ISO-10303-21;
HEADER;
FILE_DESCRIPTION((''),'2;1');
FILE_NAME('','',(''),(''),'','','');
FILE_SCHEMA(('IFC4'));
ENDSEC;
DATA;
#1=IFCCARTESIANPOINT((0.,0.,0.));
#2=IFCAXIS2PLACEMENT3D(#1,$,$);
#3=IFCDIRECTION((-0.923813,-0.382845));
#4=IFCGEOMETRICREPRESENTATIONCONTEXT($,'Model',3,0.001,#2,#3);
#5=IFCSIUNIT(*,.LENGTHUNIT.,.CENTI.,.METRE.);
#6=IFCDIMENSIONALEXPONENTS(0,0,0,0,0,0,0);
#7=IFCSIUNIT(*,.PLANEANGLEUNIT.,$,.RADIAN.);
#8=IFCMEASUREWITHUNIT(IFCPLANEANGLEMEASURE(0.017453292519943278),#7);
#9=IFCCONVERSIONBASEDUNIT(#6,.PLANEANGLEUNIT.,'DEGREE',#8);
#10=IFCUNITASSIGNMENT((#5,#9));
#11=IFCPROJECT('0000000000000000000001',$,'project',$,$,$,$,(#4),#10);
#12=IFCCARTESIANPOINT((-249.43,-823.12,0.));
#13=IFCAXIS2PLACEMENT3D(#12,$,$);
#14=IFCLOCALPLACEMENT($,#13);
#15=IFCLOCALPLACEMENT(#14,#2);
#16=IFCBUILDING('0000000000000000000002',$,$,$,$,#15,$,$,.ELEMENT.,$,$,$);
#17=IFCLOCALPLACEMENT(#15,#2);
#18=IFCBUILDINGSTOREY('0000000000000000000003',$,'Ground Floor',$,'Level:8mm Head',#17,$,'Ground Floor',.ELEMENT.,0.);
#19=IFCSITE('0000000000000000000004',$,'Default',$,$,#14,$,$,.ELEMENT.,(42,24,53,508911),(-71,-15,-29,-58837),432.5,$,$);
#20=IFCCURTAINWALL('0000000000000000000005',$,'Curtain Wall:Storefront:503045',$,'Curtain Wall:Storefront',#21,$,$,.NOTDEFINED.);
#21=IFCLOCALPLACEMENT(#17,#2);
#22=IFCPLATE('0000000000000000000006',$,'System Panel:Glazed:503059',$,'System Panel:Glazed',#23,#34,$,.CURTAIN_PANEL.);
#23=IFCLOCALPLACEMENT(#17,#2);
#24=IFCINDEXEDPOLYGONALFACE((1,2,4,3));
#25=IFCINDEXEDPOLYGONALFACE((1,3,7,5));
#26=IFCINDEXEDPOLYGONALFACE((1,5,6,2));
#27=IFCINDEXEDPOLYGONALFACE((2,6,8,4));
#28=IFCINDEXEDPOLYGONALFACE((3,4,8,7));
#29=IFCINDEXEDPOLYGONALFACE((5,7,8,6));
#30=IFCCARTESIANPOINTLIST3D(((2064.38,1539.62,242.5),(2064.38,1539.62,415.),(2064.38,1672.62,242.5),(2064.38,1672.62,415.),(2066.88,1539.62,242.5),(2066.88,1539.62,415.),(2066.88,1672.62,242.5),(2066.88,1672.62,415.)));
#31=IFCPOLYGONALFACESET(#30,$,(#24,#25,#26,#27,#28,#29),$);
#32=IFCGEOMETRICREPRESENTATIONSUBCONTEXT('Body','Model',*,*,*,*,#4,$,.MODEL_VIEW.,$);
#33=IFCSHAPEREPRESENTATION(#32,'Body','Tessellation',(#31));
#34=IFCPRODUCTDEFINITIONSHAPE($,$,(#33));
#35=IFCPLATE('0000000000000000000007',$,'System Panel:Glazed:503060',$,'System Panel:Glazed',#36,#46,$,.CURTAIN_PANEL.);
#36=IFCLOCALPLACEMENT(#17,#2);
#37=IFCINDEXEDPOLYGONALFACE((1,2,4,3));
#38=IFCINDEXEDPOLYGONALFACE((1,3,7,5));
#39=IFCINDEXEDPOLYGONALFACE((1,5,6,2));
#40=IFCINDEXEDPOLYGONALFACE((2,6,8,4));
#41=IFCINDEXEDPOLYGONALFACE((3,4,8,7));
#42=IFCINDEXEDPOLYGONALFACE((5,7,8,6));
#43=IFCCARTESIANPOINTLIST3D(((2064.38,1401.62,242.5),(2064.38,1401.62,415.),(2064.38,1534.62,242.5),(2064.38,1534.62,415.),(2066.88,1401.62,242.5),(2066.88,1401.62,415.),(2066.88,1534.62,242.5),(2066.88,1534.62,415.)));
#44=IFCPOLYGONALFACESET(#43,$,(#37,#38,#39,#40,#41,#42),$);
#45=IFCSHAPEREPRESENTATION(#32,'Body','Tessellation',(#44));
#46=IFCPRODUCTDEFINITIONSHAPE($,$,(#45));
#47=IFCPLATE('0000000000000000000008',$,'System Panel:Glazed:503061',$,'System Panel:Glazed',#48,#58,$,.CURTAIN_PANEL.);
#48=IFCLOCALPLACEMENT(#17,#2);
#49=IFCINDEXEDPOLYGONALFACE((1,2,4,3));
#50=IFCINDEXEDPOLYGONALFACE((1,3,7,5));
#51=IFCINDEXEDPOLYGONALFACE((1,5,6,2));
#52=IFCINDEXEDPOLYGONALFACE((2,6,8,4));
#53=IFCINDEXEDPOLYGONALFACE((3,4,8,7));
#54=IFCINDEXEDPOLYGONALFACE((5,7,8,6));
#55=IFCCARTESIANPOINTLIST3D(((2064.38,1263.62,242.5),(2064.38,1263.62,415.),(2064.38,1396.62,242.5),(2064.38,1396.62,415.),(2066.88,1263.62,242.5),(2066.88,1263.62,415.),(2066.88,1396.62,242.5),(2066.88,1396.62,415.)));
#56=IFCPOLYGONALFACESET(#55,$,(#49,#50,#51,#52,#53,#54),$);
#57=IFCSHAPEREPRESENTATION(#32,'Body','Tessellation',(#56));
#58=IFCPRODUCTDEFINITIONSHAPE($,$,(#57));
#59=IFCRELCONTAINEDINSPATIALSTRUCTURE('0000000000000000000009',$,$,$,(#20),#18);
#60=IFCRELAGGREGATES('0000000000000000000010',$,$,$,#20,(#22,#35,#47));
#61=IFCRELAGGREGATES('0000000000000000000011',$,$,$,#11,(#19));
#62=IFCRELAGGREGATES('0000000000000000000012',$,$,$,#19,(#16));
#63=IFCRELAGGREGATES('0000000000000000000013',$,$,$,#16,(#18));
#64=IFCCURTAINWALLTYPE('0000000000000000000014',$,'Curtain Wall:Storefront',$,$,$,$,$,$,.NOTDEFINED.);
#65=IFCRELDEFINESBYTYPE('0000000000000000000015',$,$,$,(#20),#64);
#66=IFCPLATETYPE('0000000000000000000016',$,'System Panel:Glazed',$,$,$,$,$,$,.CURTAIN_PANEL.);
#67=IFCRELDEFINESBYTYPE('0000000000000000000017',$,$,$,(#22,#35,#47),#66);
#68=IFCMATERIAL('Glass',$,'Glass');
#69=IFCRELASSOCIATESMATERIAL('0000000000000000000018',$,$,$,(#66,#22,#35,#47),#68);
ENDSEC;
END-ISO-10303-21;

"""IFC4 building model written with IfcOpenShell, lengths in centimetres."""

from ifc_helpers import new_model, entity, si_unit, converted_unit, direction, frame, origin, place, context, subcontext, project, spatial, indexed_curve, outline, extrude, source, transform, mapped, material, type_object, type_shapes, element, aggregate, save


model = new_model("IFC4")

# Units and contexts
model_context = context("Model", 3, precision=0.001, world=origin(), true_north=direction((-0.923813, -0.382845)))
body_context = subcontext(model_context, "Body", "Model", "MODEL_VIEW")
ifc_project = project(units=[si_unit("LENGTHUNIT", "METRE", prefix="CENTI"), converted_unit("PLANEANGLEUNIT", "DEGREE", entity("IfcPlaneAngleMeasure", 0.017453292519943278), si_unit("PLANEANGLEUNIT", "RADIAN"), dimensions=[0, 0, 0, 0, 0, 0, 0])], contexts=[model_context])

# Site, building, storey
site_placement = place(None, frame((-249.43, -823.12, 0.0)))
site = spatial("IfcSite", under=ifc_project, at=site_placement, Name="Default", CompositionType="ELEMENT", RefLatitude=(42, 24, 53, 508911), RefLongitude=(-71, -15, -29, -58837), RefElevation=432.5)
building_placement = place(site_placement, origin())
building = spatial("IfcBuilding", under=site, at=building_placement, CompositionType="ELEMENT")
storey_placement = place(building_placement, origin())
storey = spatial("IfcBuildingStorey", under=building, at=storey_placement, Name="Ground Floor", ObjectType="Level:8mm Head", LongName="Ground Floor", CompositionType="ELEMENT", Elevation=0.0)

# Curtain wall, plates
curtain_wall_type = type_object("IfcCurtainWallType", Name="Curtain Wall:Storefront", PredefinedType="NOTDEFINED")
curtain_wall_placement = place(storey_placement, origin())
curtain_wall = element("IfcCurtainWall", 1, at=curtain_wall_placement, inside=storey, type_object=curtain_wall_type, Name="Curtain Wall:Storefront:503045", ObjectType="Curtain Wall:Storefront", PredefinedType="NOTDEFINED")
ifc_material_1 = material(Name="Glass", Category="Glass")
plate_type_1 = type_object("IfcPlateType", Name="System Panel:Glazed", PredefinedType="CURTAIN_PANEL", material=ifc_material_1)
shared_shape_1 = source(origin(), body_context, "Body", "SweptSolid", [
    extrude(outline(indexed_curve([(-1.25, -66.5), (1.25, -66.5), (1.25, 66.5), (-1.25, 66.5), (-1.25, -66.5)], self_intersect=False)), frame((0.0, 3.7, 0.0), z_axis=(0.0, 0.0, 1.0), x_axis=(0.0, 1.0, 0.0)), (0.0, 0.0, 1.0), 172.5),
])
type_shapes(plate_type_1, [shared_shape_1])
plate_1_placement = place(curtain_wall_placement, frame((2061.93, 1606.12, 242.5), z_axis=(0.0, 0.0, 1.0), x_axis=(0.0, -1.0, 0.0)))
plate_1 = element("IfcPlate", 2, at=plate_1_placement, type_object=plate_type_1, material=ifc_material_1, Name="System Panel:Glazed:503059", ObjectType="System Panel:Glazed", PredefinedType="CURTAIN_PANEL", context=body_context, shape_type="MappedRepresentation", body=[
    mapped(shared_shape_1, transform((0.0, 0.0, 0.0), scale=1.0)),
])
plate_2_placement = place(curtain_wall_placement, frame((2061.93, 1468.12, 242.5), z_axis=(0.0, 0.0, 1.0), x_axis=(0.0, -1.0, 0.0)))
plate_2 = element("IfcPlate", 3, at=plate_2_placement, type_object=plate_type_1, material=ifc_material_1, Name="System Panel:Glazed:503060", ObjectType="System Panel:Glazed", PredefinedType="CURTAIN_PANEL", context=body_context, shape_type="MappedRepresentation", body=[
    mapped(shared_shape_1, transform((0.0, 0.0, 0.0), scale=1.0)),
])
plate_3_placement = place(curtain_wall_placement, frame((2061.93, 1330.12, 242.5), z_axis=(0.0, 0.0, 1.0), x_axis=(0.0, -1.0, 0.0)))
plate_3 = element("IfcPlate", 4, at=plate_3_placement, type_object=plate_type_1, material=ifc_material_1, Name="System Panel:Glazed:503061", ObjectType="System Panel:Glazed", PredefinedType="CURTAIN_PANEL", context=body_context, shape_type="MappedRepresentation", body=[
    mapped(shared_shape_1, transform((0.0, 0.0, 0.0), scale=1.0)),
])
aggregate(curtain_wall, [plate_1, plate_2, plate_3])

save(model, "model.ifc")
